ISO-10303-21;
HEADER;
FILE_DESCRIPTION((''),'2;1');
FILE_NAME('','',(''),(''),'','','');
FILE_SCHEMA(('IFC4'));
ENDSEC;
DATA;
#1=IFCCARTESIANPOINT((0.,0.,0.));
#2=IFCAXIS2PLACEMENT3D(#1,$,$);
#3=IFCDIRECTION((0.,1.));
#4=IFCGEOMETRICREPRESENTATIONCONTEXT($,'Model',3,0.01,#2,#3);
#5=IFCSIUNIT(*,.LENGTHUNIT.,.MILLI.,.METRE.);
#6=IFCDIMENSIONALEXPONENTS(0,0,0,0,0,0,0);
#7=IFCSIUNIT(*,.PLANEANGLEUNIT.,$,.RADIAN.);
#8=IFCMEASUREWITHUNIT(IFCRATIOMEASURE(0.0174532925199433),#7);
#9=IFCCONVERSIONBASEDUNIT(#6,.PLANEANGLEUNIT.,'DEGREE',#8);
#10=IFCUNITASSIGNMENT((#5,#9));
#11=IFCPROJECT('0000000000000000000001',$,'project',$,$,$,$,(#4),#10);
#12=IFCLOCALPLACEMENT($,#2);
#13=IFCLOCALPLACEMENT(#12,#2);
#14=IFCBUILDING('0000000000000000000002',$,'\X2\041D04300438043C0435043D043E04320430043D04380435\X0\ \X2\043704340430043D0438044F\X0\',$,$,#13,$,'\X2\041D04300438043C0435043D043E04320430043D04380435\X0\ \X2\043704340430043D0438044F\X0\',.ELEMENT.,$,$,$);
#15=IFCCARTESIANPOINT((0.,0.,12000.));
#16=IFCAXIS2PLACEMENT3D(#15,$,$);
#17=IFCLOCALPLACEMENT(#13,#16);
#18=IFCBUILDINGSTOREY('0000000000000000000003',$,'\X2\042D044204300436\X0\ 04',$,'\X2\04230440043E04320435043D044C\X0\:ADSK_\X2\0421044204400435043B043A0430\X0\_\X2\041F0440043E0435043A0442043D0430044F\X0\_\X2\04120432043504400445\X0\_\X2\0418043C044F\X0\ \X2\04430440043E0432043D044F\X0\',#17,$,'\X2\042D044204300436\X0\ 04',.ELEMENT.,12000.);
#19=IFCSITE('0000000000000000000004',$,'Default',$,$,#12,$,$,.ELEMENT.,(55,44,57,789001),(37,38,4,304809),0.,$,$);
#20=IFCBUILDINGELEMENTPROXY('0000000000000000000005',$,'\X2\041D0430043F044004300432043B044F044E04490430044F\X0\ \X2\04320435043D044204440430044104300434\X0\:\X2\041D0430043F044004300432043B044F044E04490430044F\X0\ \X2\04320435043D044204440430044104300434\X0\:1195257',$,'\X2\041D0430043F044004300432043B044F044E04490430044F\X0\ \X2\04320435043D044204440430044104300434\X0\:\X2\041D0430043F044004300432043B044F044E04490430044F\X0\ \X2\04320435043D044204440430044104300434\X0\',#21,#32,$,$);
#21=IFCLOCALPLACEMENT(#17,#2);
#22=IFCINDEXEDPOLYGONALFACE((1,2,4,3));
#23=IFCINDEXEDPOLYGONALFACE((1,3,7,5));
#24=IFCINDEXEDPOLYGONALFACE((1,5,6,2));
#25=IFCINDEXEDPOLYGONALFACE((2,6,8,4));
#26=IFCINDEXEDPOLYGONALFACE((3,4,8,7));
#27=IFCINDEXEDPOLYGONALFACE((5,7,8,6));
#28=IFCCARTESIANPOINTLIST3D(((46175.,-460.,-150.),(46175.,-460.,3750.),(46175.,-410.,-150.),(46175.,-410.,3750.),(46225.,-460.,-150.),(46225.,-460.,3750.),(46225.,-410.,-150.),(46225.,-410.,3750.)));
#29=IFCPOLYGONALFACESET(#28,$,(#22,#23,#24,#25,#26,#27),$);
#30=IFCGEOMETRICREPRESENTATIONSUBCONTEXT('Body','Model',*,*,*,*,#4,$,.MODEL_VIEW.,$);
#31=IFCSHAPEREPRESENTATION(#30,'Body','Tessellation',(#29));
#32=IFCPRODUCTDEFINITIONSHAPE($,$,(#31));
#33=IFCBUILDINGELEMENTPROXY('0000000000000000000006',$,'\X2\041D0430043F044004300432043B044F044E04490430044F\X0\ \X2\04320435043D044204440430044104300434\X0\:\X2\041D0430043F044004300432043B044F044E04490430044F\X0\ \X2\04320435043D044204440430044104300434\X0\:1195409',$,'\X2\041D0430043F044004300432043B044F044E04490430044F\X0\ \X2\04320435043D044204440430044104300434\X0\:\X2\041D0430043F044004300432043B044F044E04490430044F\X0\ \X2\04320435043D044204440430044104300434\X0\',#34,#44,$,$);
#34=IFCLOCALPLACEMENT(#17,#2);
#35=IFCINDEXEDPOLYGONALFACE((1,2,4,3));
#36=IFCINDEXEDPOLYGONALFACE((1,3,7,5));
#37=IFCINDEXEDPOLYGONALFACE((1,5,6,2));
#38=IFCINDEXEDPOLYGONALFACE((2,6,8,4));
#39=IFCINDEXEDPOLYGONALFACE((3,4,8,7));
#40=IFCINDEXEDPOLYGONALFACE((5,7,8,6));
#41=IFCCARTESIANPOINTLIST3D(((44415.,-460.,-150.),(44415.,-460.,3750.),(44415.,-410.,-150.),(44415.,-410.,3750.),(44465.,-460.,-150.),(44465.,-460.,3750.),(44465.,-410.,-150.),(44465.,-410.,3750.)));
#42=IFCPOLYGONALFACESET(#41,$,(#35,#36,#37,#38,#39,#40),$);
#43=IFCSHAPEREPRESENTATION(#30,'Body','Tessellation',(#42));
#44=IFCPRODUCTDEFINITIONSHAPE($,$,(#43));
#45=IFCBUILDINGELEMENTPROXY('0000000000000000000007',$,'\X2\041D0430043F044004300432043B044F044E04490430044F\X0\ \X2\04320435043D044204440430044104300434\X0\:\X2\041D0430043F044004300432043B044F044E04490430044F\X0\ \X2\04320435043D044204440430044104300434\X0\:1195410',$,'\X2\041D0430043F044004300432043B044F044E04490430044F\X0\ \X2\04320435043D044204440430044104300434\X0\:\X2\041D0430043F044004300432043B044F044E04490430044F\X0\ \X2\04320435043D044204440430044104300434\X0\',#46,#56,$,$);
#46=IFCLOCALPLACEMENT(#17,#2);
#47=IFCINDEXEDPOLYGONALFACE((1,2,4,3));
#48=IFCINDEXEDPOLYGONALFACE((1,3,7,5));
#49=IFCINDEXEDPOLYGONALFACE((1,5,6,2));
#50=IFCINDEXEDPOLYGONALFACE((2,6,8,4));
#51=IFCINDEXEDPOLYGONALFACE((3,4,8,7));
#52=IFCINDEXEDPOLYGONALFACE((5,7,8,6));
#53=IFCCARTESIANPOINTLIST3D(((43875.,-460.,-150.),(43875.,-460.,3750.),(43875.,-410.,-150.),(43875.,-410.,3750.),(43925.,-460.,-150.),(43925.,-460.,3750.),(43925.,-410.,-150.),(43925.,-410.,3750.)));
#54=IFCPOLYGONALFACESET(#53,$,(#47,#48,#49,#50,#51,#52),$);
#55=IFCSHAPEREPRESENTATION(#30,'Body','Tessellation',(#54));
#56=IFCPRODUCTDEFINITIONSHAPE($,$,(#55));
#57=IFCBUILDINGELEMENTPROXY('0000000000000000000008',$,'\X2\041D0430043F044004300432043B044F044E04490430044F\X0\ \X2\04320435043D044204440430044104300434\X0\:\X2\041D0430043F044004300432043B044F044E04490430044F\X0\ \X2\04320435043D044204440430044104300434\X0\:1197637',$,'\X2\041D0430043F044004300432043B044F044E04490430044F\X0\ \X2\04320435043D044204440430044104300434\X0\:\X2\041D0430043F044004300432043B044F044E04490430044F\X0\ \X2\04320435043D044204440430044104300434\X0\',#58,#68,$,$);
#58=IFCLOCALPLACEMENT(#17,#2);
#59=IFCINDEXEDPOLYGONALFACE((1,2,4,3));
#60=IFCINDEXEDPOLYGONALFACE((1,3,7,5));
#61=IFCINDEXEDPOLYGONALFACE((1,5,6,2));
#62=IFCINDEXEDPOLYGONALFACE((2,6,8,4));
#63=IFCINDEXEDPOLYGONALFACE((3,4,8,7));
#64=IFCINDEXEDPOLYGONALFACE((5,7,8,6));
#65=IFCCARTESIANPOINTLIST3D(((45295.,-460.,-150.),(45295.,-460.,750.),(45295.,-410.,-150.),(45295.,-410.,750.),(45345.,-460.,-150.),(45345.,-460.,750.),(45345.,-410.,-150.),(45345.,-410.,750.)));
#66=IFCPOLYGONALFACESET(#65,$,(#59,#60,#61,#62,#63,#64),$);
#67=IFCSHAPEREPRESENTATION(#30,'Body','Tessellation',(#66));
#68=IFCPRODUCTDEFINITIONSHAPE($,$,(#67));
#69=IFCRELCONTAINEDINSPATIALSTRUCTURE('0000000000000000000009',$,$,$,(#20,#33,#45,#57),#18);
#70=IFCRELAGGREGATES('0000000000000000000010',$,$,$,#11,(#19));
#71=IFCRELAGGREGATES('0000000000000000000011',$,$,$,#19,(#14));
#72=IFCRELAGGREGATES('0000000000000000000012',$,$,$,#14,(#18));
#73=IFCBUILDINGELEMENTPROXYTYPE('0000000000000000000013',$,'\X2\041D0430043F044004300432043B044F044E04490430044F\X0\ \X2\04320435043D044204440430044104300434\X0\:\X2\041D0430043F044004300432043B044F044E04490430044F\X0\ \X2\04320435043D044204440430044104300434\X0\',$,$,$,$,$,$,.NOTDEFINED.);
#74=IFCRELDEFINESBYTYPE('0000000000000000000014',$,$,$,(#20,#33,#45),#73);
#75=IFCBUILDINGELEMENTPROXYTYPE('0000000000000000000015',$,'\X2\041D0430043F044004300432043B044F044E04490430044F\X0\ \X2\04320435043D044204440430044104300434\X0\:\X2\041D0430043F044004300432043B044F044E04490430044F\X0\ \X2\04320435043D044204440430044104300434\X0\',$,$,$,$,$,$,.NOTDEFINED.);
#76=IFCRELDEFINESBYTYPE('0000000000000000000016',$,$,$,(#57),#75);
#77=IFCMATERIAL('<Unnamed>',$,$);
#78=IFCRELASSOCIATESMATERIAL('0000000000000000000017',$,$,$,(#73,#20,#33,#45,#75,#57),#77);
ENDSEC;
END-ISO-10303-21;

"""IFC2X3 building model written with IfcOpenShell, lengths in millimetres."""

from ifc_helpers import new_model, entity, si_unit, converted_unit, direction, frame, origin, origin_2d_with_axis, place, context, subcontext, project, spatial, rectangle, extrude, source, transform, mapped, material, type_object, type_shapes, element, save


model = new_model("IFC2X3")

# Units and contexts
model_context = context("Model", 3, precision=0.01, world=origin(), true_north=direction((0.0, 1.0)))
body_context = subcontext(model_context, "Body", "Model", "MODEL_VIEW")
ifc_project = project(units=[si_unit("LENGTHUNIT", "METRE", prefix="MILLI"), converted_unit("PLANEANGLEUNIT", "DEGREE", entity("IfcRatioMeasure", 0.0174532925199433), si_unit("PLANEANGLEUNIT", "RADIAN"), dimensions=[0, 0, 0, 0, 0, 0, 0])], contexts=[model_context])

# Site, building, storey
site_placement = place(None, origin())
site = spatial("IfcSite", under=ifc_project, at=site_placement, Name="Default", CompositionType="ELEMENT", RefLatitude=(55, 44, 57, 789001), RefLongitude=(37, 38, 4, 304809), RefElevation=0.0)
building_placement = place(site_placement, origin())
building = spatial("IfcBuilding", under=site, at=building_placement, Name="Наименование здания", LongName="Наименование здания", CompositionType="ELEMENT")
storey_placement = place(building_placement, frame((0.0, 0.0, 12000.0)))
storey = spatial("IfcBuildingStorey", under=building, at=storey_placement, Name="Этаж 04", ObjectType="Уровень:ADSK_Стрелка_Проектная_Вверх_Имя уровня", LongName="Этаж 04", CompositionType="ELEMENT", Elevation=12000.0)

# Building element proxies
ifc_material_1 = material(Name="<Unnamed>")
building_element_proxy_type_1 = type_object("IfcBuildingElementProxyType", Name="Направляющая вентфасад:Направляющая вентфасад", PredefinedType="NOTDEFINED", material=ifc_material_1)
shared_shape_1 = source(origin(), body_context, "Body", "SweptSolid", [
    extrude(rectangle(XDim=50.0, YDim=50.0, at=origin_2d_with_axis()), frame((25.0, -25.0, 0.0), z_axis=(0.0, 0.0, 1.0), x_axis=(-1.0, 0.0, 0.0)), (0.0, 0.0, 1.0), 3900.0),
])
type_shapes(building_element_proxy_type_1, [shared_shape_1])
for number, where, name in (
    (1, (46175.0, -410.0, -150.0), "Направляющая вентфасад:Направляющая вентфасад:1195257"),
    (2, (44415.0, -410.0, -150.0), "Направляющая вентфасад:Направляющая вентфасад:1195409"),
    (3, (43875.0, -410.0, -150.0), "Направляющая вентфасад:Направляющая вентфасад:1195410"),
):
    element("IfcBuildingElementProxy", number, at=place(storey_placement, frame(where)), inside=storey, type_object=building_element_proxy_type_1, material=ifc_material_1, Name=name, ObjectType="Направляющая вентфасад:Направляющая вентфасад", context=body_context, shape_type="MappedRepresentation", body=[
        mapped(shared_shape_1, transform((0.0, 0.0, 0.0), scale=1.0)),
    ])
building_element_proxy_type_2 = type_object("IfcBuildingElementProxyType", Name="Направляющая вентфасад:Направляющая вентфасад", PredefinedType="NOTDEFINED", material=ifc_material_1)
shared_shape_2 = source(origin(), body_context, "Body", "SweptSolid", [
    extrude(rectangle(XDim=50.0, YDim=50.0, at=origin_2d_with_axis()), frame((25.0, -25.0, 0.0), z_axis=(0.0, 0.0, 1.0), x_axis=(-1.0, 0.0, 0.0)), (0.0, 0.0, 1.0), 900.0),
])
type_shapes(building_element_proxy_type_2, [shared_shape_2])
proxy_1_placement = place(storey_placement, frame((45295.0, -410.0, -150.0)))
element("IfcBuildingElementProxy", 4, at=proxy_1_placement, inside=storey, type_object=building_element_proxy_type_2, material=ifc_material_1, Name="Направляющая вентфасад:Направляющая вентфасад:1197637", ObjectType="Направляющая вентфасад:Направляющая вентфасад", context=body_context, shape_type="MappedRepresentation", body=[
    mapped(shared_shape_2, transform((0.0, 0.0, 0.0), scale=1.0)),
])

save(model, "model.ifc")
